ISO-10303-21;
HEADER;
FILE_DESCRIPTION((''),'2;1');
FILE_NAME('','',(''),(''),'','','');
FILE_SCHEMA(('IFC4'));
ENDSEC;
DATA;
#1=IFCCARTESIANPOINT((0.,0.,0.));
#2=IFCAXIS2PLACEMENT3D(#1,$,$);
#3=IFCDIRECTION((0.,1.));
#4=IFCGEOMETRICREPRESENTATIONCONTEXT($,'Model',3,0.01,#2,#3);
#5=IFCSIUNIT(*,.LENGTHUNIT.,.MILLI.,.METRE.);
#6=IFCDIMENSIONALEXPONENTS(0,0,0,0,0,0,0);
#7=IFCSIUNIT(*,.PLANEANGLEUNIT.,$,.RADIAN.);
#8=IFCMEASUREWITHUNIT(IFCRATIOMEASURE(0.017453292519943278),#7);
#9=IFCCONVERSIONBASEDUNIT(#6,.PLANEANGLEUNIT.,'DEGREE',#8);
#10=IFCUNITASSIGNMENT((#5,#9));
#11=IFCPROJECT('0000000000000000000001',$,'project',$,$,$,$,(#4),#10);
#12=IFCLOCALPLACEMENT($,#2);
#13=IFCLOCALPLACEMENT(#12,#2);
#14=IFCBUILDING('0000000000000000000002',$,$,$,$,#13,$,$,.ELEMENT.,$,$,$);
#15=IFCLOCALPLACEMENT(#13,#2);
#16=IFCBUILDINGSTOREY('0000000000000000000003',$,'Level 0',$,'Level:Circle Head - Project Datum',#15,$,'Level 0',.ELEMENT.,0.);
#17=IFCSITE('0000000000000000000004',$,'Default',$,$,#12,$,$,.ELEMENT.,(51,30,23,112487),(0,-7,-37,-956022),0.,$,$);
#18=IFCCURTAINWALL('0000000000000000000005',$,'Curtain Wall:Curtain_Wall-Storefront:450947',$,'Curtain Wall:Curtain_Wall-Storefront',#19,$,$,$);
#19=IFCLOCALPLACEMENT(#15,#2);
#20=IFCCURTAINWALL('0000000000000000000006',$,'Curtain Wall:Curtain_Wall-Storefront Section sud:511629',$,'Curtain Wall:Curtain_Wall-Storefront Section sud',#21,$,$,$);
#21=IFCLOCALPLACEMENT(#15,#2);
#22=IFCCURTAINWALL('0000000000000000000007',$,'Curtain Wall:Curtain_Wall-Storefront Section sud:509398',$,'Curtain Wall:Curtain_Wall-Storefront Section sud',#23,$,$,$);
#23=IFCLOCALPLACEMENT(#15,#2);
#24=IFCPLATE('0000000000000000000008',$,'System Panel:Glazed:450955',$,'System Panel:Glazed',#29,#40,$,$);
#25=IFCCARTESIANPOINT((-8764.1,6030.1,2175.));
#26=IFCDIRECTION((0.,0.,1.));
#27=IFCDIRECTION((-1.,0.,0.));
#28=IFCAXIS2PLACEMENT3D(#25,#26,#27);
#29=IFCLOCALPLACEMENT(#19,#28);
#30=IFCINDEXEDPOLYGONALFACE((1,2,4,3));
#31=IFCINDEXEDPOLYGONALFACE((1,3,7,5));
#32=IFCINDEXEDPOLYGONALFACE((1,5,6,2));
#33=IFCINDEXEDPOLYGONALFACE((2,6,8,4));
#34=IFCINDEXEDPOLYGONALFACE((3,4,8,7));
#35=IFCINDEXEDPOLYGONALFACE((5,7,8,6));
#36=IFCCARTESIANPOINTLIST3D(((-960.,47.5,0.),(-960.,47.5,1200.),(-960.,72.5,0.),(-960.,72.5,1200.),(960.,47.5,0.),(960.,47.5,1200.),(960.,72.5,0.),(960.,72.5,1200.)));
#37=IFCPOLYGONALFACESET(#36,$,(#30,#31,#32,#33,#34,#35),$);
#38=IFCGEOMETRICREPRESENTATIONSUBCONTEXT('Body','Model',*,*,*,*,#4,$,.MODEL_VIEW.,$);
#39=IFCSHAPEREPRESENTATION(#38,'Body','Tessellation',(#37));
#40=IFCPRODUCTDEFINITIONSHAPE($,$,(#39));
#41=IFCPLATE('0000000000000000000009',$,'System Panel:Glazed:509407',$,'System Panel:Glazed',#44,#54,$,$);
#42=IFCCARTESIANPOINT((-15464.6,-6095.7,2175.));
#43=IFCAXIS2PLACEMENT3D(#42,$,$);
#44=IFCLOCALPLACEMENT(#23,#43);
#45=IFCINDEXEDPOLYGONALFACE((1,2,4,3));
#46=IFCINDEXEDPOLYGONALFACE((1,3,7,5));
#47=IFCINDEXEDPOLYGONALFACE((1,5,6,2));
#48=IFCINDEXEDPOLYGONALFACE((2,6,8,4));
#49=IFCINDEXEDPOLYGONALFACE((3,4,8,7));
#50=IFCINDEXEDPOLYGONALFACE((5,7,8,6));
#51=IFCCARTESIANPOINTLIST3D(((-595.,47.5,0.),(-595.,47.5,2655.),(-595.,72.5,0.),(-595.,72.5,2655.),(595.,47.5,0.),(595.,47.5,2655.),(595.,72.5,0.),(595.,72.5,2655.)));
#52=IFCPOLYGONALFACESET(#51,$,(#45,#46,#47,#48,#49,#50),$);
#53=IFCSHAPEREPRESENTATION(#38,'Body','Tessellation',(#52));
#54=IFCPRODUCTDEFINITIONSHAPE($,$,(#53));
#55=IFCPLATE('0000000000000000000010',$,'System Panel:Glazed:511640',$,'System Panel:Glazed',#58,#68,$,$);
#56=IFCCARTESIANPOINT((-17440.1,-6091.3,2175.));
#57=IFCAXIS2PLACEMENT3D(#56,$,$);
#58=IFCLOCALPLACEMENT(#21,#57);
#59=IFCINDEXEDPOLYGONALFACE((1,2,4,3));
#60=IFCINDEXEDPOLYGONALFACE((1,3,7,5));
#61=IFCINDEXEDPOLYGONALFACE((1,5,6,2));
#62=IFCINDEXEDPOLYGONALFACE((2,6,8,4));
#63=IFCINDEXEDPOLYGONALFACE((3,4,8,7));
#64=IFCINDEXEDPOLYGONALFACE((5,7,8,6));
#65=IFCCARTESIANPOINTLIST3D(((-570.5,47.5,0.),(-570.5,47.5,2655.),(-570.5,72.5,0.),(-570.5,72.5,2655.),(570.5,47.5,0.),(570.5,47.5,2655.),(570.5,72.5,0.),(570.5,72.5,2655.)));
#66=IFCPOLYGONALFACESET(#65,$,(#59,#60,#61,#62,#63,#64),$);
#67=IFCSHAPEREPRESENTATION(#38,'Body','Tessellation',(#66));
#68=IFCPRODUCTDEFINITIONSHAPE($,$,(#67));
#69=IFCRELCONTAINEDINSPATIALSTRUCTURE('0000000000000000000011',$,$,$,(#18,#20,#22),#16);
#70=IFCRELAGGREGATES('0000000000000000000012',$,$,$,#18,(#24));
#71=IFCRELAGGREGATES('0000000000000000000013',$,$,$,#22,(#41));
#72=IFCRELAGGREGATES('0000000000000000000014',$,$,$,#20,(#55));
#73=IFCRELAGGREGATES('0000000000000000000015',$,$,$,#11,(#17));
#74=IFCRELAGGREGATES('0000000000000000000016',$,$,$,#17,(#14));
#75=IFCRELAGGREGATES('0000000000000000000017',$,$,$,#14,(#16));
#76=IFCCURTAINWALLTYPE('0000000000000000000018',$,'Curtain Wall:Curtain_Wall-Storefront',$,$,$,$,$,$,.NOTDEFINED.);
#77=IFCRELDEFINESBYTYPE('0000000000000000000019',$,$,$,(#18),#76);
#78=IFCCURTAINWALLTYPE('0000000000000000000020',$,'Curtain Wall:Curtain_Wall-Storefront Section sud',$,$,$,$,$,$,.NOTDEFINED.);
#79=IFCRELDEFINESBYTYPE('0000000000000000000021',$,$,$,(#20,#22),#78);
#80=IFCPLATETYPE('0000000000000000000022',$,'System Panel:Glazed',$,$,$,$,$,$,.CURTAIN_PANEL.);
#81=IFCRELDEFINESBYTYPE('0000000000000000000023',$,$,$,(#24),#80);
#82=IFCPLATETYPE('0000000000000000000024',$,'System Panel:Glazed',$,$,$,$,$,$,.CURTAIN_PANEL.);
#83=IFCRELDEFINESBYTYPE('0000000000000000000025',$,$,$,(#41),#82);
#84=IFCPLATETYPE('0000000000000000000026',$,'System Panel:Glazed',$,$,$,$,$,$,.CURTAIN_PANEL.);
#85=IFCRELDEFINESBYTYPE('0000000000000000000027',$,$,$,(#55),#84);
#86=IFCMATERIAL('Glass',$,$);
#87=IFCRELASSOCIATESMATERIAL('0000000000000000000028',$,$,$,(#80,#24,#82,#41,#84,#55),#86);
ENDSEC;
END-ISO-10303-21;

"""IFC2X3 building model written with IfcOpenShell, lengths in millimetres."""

from ifc_helpers import new_model, entity, si_unit, converted_unit, direction, frame, frame_2d, origin, origin_2d_with_axis, place, context, subcontext, project, spatial, rectangle, extrude, source, transform, mapped, material, type_object, type_shapes, element, aggregate, save


model = new_model("IFC2X3")

# Units and contexts
model_context = context("Model", 3, precision=0.01, world=origin(), true_north=direction((0.0, 1.0)))
body_context = subcontext(model_context, "Body", "Model", "MODEL_VIEW")
ifc_project = project(units=[si_unit("LENGTHUNIT", "METRE", prefix="MILLI"), converted_unit("PLANEANGLEUNIT", "DEGREE", entity("IfcRatioMeasure", 0.017453292519943278), si_unit("PLANEANGLEUNIT", "RADIAN"), dimensions=[0, 0, 0, 0, 0, 0, 0])], contexts=[model_context])

# Site, building, storey
site_placement = place(None, origin())
site = spatial("IfcSite", under=ifc_project, at=site_placement, Name="Default", CompositionType="ELEMENT", RefLatitude=(51, 30, 23, 112487), RefLongitude=(0, -7, -37, -956022), RefElevation=0.0)
building_placement = place(site_placement, origin())
building = spatial("IfcBuilding", under=site, at=building_placement, CompositionType="ELEMENT")
storey_placement = place(building_placement, origin())
storey = spatial("IfcBuildingStorey", under=building, at=storey_placement, Name="Level 0", ObjectType="Level:Circle Head - Project Datum", LongName="Level 0", CompositionType="ELEMENT", Elevation=0.0)

# Curtain walls
curtain_wall_type_1 = type_object("IfcCurtainWallType", Name="Curtain Wall:Curtain_Wall-Storefront", PredefinedType="NOTDEFINED")
curtain_wall_1_placement = place(storey_placement, origin())
curtain_wall_1 = element("IfcCurtainWall", 1, at=curtain_wall_1_placement, inside=storey, type_object=curtain_wall_type_1, Name="Curtain Wall:Curtain_Wall-Storefront:450947", ObjectType="Curtain Wall:Curtain_Wall-Storefront")
curtain_wall_type_2 = type_object("IfcCurtainWallType", Name="Curtain Wall:Curtain_Wall-Storefront Section sud", PredefinedType="NOTDEFINED")
curtain_wall_2_placement = place(storey_placement, origin())
curtain_wall_2 = element("IfcCurtainWall", 2, at=curtain_wall_2_placement, inside=storey, type_object=curtain_wall_type_2, Name="Curtain Wall:Curtain_Wall-Storefront Section sud:511629", ObjectType="Curtain Wall:Curtain_Wall-Storefront Section sud")
curtain_wall_3_placement = place(storey_placement, origin())
curtain_wall_3 = element("IfcCurtainWall", 3, at=curtain_wall_3_placement, inside=storey, type_object=curtain_wall_type_2, Name="Curtain Wall:Curtain_Wall-Storefront Section sud:509398", ObjectType="Curtain Wall:Curtain_Wall-Storefront Section sud")

# Plates
ifc_material_1 = material(Name="Glass")
plate_type_1 = type_object("IfcPlateType", Name="System Panel:Glazed", PredefinedType="CURTAIN_PANEL", material=ifc_material_1)
shared_shape_1 = source(origin(), body_context, "Body", "SweptSolid", [
    extrude(rectangle(XDim=25.0, YDim=1920.0, at=origin_2d_with_axis()), frame((0.0, 60.0, 0.0), z_axis=(0.0, 0.0, 1.0), x_axis=(0.0, 1.0, 0.0)), (0.0, 0.0, 1.0), 1200.0),
])
type_shapes(plate_type_1, [shared_shape_1])
plate_1_placement = place(curtain_wall_1_placement, frame((-8764.1, 6030.1, 2175.0), z_axis=(0.0, 0.0, 1.0), x_axis=(-1.0, 0.0, 0.0)))
plate_1 = element("IfcPlate", 4, at=plate_1_placement, type_object=plate_type_1, material=ifc_material_1, Name="System Panel:Glazed:450955", ObjectType="System Panel:Glazed", context=body_context, shape_type="MappedRepresentation", body=[
    mapped(shared_shape_1, transform((0.0, 0.0, 0.0), scale=1.0)),
])
aggregate(curtain_wall_1, [plate_1])
plate_type_2 = type_object("IfcPlateType", Name="System Panel:Glazed", PredefinedType="CURTAIN_PANEL", material=ifc_material_1)
shared_shape_2 = source(origin(), body_context, "Body", "SweptSolid", [
    extrude(rectangle(XDim=25.0, YDim=1190.0, at=frame_2d((0.0, 0.0), x_axis=(1.0, 0.0))), frame((0.0, 60.0, 0.0), z_axis=(0.0, 0.0, 1.0), x_axis=(0.0, 1.0, 0.0)), (0.0, 0.0, 1.0), 2655.0),
])
type_shapes(plate_type_2, [shared_shape_2])
plate_2_placement = place(curtain_wall_3_placement, frame((-15464.6, -6095.7, 2175.0)))
plate_2 = element("IfcPlate", 5, at=plate_2_placement, type_object=plate_type_2, material=ifc_material_1, Name="System Panel:Glazed:509407", ObjectType="System Panel:Glazed", context=body_context, shape_type="MappedRepresentation", body=[
    mapped(shared_shape_2, transform((0.0, 0.0, 0.0), scale=1.0)),
])
aggregate(curtain_wall_3, [plate_2])
plate_type_3 = type_object("IfcPlateType", Name="System Panel:Glazed", PredefinedType="CURTAIN_PANEL", material=ifc_material_1)
shared_shape_3 = source(origin(), body_context, "Body", "SweptSolid", [
    extrude(rectangle(XDim=25.0, YDim=1141.0, at=frame_2d((0.0, 0.0), x_axis=(1.0, 0.0))), frame((0.0, 60.0, 0.0), z_axis=(0.0, 0.0, 1.0), x_axis=(0.0, 1.0, 0.0)), (0.0, 0.0, 1.0), 2655.0),
])
type_shapes(plate_type_3, [shared_shape_3])
plate_3_placement = place(curtain_wall_2_placement, frame((-17440.1, -6091.3, 2175.0)))
plate_3 = element("IfcPlate", 6, at=plate_3_placement, type_object=plate_type_3, material=ifc_material_1, Name="System Panel:Glazed:511640", ObjectType="System Panel:Glazed", context=body_context, shape_type="MappedRepresentation", body=[
    mapped(shared_shape_3, transform((0.0, 0.0, 0.0), scale=1.0)),
])
aggregate(curtain_wall_2, [plate_3])

save(model, "model.ifc")
